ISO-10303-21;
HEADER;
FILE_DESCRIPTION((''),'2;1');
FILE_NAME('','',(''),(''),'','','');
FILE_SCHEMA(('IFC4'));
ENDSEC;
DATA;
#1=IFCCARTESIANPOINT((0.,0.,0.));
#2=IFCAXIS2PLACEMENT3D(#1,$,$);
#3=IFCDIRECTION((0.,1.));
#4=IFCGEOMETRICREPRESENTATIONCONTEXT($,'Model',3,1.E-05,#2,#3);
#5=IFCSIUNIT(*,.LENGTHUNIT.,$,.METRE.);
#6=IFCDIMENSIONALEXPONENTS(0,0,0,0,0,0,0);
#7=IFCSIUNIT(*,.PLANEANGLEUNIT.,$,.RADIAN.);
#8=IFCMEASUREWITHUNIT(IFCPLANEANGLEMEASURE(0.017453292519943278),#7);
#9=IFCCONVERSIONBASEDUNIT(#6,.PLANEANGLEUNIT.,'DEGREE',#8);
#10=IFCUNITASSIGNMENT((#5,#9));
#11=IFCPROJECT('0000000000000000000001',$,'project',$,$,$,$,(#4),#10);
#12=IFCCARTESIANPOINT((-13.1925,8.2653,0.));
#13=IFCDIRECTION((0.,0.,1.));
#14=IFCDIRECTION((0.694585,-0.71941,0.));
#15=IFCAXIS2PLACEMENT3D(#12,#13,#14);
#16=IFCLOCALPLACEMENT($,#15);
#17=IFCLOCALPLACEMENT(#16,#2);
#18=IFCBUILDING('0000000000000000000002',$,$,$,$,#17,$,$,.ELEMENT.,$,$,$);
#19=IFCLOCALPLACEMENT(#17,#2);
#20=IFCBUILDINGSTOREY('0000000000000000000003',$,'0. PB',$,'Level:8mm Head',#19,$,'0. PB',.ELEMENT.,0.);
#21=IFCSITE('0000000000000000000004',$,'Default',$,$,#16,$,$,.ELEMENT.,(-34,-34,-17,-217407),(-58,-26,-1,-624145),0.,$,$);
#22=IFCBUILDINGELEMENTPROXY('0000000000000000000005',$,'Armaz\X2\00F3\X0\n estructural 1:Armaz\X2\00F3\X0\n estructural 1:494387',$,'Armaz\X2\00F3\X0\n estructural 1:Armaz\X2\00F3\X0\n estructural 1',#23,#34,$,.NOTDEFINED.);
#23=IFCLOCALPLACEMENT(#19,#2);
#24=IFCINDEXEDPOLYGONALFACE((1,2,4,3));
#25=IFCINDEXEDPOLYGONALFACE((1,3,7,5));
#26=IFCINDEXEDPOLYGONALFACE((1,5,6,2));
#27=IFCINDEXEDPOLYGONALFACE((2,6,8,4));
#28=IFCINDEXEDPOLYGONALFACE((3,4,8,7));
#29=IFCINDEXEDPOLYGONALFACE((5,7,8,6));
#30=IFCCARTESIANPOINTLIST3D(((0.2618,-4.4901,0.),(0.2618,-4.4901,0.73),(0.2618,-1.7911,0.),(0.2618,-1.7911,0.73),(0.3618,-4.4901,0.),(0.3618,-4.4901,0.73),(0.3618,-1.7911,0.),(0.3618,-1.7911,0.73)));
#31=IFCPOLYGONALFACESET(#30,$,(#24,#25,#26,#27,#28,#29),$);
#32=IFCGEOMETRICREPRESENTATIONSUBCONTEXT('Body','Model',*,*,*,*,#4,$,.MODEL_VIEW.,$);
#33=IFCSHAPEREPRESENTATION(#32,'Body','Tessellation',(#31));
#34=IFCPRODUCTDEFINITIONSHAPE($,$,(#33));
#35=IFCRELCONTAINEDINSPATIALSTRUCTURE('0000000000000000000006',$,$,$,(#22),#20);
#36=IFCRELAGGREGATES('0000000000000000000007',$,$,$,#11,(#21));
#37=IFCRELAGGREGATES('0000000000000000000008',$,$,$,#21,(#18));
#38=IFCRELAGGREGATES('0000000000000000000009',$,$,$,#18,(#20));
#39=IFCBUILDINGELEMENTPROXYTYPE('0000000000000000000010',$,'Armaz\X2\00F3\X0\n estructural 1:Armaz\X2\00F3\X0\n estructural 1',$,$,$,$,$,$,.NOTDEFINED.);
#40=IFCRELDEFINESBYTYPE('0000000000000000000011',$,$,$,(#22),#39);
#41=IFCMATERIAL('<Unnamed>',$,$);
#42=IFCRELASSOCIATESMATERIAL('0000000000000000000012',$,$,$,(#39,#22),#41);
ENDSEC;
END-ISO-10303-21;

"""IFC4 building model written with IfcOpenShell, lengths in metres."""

from ifc_helpers import new_model, entity, si_unit, converted_unit, direction, frame, origin, place, context, subcontext, project, spatial, indexed_curve, outline, extrude, source, transform, mapped, material, type_object, type_shapes, element, save


model = new_model("IFC4")

# Units and contexts
model_context = context("Model", 3, precision=1e-05, world=origin(), true_north=direction((0.0, 1.0)))
body_context = subcontext(model_context, "Body", "Model", "MODEL_VIEW")
ifc_project = project(units=[si_unit("LENGTHUNIT", "METRE"), converted_unit("PLANEANGLEUNIT", "DEGREE", entity("IfcPlaneAngleMeasure", 0.017453292519943278), si_unit("PLANEANGLEUNIT", "RADIAN"), dimensions=[0, 0, 0, 0, 0, 0, 0])], contexts=[model_context])

# Site, building, storey
site_placement = place(None, frame((-13.1925, 8.2653, 0.0), z_axis=(0.0, 0.0, 1.0), x_axis=(0.694585, -0.71941, 0.0)))
site = spatial("IfcSite", under=ifc_project, at=site_placement, Name="Default", CompositionType="ELEMENT", RefLatitude=(-34, -34, -17, -217407), RefLongitude=(-58, -26, -1, -624145), RefElevation=0.0)
building_placement = place(site_placement, origin())
building = spatial("IfcBuilding", under=site, at=building_placement, CompositionType="ELEMENT")
storey_placement = place(building_placement, origin())
storey = spatial("IfcBuildingStorey", under=building, at=storey_placement, Name="0. PB", ObjectType="Level:8mm Head", LongName="0. PB", CompositionType="ELEMENT", Elevation=0.0)

# Shared definitions
ifc_material_1 = material(Name="<Unnamed>")

# Building element proxy
building_element_proxy_type = type_object("IfcBuildingElementProxyType", Name="Armazón estructural 1:Armazón estructural 1", PredefinedType="NOTDEFINED", material=ifc_material_1)
shared_shape_1 = source(origin(), body_context, "Body", "SweptSolid", [
    extrude(outline(indexed_curve([(-0.05, -1.3495), (0.05, -1.3495), (0.05, 1.3495), (-0.05, 1.3495), (-0.05, -1.3495)], self_intersect=False)), frame((0.3118, -3.1406, 0.0)), (0.0, 0.0, 1.0), 0.73),
])
type_shapes(building_element_proxy_type, [shared_shape_1])
proxy_placement = place(storey_placement, origin())
element("IfcBuildingElementProxy", 1, at=proxy_placement, inside=storey, type_object=building_element_proxy_type, material=ifc_material_1, Name="Armazón estructural 1:Armazón estructural 1:494387", ObjectType="Armazón estructural 1:Armazón estructural 1", PredefinedType="NOTDEFINED", context=body_context, shape_type="MappedRepresentation", body=[
    mapped(shared_shape_1, transform((0.0, 0.0, 0.0), scale=1.0)),
])

save(model, "model.ifc")
